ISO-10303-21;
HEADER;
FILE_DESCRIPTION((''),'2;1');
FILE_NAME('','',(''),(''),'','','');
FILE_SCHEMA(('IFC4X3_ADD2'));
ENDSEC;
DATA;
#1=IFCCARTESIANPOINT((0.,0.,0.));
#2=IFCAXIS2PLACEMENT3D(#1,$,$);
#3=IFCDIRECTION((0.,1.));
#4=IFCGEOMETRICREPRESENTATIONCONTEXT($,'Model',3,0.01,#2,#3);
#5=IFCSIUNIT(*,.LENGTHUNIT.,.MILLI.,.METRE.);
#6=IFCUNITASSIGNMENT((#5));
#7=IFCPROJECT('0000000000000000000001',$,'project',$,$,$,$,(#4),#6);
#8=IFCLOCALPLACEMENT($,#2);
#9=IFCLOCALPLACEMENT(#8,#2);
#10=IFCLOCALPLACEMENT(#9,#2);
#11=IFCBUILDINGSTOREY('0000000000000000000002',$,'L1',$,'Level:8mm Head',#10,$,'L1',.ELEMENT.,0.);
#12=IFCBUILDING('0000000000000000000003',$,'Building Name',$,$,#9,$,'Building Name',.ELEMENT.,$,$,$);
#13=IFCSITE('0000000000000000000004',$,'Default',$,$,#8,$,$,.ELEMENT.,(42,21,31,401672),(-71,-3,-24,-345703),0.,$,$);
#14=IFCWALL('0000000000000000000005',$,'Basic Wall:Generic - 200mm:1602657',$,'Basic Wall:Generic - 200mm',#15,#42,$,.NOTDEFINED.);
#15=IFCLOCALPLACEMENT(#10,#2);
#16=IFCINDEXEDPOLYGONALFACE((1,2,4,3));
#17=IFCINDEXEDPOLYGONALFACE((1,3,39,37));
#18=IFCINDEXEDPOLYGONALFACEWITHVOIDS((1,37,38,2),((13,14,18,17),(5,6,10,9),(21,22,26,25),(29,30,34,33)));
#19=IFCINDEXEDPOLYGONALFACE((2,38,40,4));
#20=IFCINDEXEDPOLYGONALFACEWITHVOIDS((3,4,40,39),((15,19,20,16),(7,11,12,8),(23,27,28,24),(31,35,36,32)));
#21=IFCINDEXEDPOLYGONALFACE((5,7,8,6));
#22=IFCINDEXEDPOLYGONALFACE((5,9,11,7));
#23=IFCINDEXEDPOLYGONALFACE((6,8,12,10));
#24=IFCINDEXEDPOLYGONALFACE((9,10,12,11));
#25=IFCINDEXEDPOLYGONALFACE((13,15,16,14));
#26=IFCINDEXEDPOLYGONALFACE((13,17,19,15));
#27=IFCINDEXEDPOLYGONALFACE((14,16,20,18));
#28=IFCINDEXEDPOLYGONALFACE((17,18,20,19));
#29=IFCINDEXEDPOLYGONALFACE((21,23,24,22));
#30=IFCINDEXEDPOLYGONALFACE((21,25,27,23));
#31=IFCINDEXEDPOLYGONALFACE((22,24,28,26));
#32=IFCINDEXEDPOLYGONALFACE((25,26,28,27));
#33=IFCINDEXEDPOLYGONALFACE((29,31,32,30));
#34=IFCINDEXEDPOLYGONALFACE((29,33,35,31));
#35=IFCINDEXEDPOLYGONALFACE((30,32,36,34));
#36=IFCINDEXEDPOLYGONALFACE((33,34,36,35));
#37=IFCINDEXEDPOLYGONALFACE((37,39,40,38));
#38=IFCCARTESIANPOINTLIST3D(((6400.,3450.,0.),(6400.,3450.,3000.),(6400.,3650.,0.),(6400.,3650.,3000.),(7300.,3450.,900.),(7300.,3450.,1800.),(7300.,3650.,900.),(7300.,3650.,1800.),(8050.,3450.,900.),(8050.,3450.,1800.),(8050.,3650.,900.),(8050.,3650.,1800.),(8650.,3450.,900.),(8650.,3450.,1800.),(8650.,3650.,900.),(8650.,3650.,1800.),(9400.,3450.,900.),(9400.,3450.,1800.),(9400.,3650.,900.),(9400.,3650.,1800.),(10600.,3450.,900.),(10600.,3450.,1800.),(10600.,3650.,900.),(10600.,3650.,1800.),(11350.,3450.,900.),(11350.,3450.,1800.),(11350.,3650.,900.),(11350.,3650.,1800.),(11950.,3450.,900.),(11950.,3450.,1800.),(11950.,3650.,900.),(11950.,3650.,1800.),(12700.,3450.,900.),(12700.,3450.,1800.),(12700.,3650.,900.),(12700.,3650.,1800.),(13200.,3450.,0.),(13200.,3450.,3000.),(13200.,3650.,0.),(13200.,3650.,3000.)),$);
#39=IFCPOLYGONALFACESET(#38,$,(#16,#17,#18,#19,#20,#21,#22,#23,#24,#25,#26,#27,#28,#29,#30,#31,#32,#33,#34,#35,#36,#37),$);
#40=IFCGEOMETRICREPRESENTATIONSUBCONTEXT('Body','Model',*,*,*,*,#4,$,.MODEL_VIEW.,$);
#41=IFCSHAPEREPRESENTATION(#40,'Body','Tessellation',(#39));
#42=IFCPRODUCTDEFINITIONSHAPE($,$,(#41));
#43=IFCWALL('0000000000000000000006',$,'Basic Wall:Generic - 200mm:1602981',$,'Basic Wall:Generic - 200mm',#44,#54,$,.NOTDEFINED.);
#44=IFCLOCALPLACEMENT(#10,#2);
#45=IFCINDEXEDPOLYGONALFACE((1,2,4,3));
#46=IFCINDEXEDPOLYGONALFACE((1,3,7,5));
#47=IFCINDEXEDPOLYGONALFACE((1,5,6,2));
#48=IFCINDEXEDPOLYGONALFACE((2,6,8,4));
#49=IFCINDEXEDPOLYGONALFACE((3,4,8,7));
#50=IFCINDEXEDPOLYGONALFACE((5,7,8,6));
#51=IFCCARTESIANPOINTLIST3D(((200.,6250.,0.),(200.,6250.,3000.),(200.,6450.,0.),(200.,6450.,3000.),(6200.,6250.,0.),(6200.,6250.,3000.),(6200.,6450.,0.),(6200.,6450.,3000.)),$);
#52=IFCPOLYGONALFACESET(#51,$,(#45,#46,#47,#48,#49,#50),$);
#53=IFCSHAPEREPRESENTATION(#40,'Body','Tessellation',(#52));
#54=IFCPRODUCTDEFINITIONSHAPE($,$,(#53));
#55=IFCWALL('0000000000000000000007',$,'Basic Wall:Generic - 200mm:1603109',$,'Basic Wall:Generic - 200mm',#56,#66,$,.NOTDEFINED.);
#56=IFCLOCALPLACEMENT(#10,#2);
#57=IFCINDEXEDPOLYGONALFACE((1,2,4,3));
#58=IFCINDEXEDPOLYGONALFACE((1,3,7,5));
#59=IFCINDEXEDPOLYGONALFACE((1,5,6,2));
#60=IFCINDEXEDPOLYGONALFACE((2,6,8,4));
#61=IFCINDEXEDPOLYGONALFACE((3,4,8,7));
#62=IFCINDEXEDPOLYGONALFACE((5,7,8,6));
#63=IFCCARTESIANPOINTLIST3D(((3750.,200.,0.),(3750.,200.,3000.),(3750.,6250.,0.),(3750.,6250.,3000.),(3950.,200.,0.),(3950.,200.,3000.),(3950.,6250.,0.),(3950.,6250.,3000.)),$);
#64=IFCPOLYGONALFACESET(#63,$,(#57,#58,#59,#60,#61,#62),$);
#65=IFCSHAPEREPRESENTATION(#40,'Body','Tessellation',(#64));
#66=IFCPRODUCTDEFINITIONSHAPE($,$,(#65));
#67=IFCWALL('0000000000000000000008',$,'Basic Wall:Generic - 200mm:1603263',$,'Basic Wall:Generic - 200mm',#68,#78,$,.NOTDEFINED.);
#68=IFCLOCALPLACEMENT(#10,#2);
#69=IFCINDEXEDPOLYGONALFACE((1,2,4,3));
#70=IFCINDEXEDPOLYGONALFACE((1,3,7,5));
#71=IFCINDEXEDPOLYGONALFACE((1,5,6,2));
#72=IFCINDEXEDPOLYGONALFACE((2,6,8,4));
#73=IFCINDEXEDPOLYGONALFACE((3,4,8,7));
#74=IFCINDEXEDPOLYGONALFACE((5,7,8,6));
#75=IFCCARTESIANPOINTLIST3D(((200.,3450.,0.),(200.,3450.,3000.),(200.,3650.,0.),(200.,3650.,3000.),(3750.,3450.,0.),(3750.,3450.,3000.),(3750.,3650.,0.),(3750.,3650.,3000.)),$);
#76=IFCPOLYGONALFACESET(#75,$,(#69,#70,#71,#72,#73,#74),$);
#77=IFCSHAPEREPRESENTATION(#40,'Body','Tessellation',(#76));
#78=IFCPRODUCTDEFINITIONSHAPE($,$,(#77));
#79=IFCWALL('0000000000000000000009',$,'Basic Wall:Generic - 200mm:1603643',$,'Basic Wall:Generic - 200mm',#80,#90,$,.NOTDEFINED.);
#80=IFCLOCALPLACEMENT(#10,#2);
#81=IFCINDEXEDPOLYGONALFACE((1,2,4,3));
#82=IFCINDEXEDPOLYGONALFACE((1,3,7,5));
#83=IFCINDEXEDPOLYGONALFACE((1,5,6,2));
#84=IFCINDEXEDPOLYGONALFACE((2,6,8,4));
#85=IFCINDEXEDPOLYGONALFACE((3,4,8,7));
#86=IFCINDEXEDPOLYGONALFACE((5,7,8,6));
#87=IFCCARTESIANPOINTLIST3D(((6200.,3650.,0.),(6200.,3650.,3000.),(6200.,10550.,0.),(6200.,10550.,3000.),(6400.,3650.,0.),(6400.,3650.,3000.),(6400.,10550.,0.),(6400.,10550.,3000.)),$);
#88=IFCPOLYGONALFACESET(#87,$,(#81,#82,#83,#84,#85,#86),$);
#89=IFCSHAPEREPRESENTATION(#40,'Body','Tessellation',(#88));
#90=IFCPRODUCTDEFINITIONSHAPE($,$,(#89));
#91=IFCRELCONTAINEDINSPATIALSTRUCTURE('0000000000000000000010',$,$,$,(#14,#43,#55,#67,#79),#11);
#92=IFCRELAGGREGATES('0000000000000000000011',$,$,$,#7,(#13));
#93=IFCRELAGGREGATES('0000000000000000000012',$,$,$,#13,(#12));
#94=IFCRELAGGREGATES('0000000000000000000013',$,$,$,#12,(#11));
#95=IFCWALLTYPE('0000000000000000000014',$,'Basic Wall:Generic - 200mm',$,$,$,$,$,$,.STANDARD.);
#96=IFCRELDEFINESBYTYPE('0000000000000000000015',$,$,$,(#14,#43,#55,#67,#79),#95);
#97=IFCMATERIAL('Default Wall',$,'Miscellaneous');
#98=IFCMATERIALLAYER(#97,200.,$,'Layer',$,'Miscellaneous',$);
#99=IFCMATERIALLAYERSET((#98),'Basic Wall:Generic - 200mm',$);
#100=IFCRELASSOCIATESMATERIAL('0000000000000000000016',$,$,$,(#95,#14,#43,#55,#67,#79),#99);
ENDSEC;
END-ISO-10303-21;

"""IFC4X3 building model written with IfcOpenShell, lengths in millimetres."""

from ifc_helpers import new_model, si_unit, direction, frame, frame_2d, origin, place, context, subcontext, project, spatial, rectangle, extrude, material, layer, layer_set, type_object, element, save


model = new_model("IFC4X3")

# Units and contexts
model_context = context("Model", 3, precision=0.01, world=origin(), true_north=direction((0.0, 1.0)))
body_context = subcontext(model_context, "Body", "Model", "MODEL_VIEW")
ifc_project = project(units=[si_unit("LENGTHUNIT", "METRE", prefix="MILLI")], contexts=[model_context])

# Site, building, storey
site_placement = place(None, origin())
site = spatial("IfcSite", under=ifc_project, at=site_placement, Name="Default", CompositionType="ELEMENT", RefLatitude=(42, 21, 31, 401672), RefLongitude=(-71, -3, -24, -345703), RefElevation=0.0)
building_placement = place(site_placement, origin())
building = spatial("IfcBuilding", under=site, at=building_placement, Name="Building Name", LongName="Building Name", CompositionType="ELEMENT")
storey_placement = place(building_placement, origin())
storey = spatial("IfcBuildingStorey", under=building, at=storey_placement, Name="L1", ObjectType="Level:8mm Head", LongName="L1", CompositionType="ELEMENT", Elevation=0.0)

# Shared definitions
ifc_material = material(Name="Default Wall", Category="Miscellaneous")
ifc_layer = layer(ifc_material, 200.0, Name="Layer", Category="Miscellaneous")
ifc_layer_set = layer_set([ifc_layer], Name="Basic Wall:Generic - 200mm")
wall_type = type_object("IfcWallType", Name="Basic Wall:Generic - 200mm", PredefinedType="STANDARD", material=ifc_layer_set)

# Wall, openings
wall_1_placement = place(storey_placement, frame((6400.0, 3550.0, 0.0)))
wall_1 = element("IfcWall", 1, at=wall_1_placement, inside=storey, type_object=wall_type, material=ifc_layer_set, Name="Basic Wall:Generic - 200mm:1602657", ObjectType="Basic Wall:Generic - 200mm", PredefinedType="NOTDEFINED", context=body_context, shape_type="SweptSolid", body=[
    extrude(rectangle(XDim=6800.0, YDim=200.0, at=frame_2d((3400.0, 0.0), x_axis=(-1.0, 0.0))), origin(), (0.0, 0.0, 1.0), 3000.0),
])
opening_1_placement = place(wall_1_placement, frame((1650.0, 100.0, 900.0)))
element("IfcOpeningElement", 2, at=opening_1_placement, cuts=wall_1, PredefinedType="OPENING", context=body_context, shape_type="SweptSolid", body=[
    extrude(rectangle(XDim=900.0, YDim=750.0, at=frame_2d((450.0, 375.0), x_axis=(-1.0, 0.0))), frame((0.0, 0.0, 0.0), z_axis=(0.0, -1.0, 0.0), x_axis=(0.0, 0.0, 1.0)), (0.0, 0.0, 1.0), 200.0),
])
opening_2_placement = place(wall_1_placement, frame((3000.0, 100.0, 900.0)))
element("IfcOpeningElement", 3, at=opening_2_placement, cuts=wall_1, PredefinedType="OPENING", context=body_context, shape_type="SweptSolid", body=[
    extrude(rectangle(XDim=900.0, YDim=750.0, at=frame_2d((450.0, 375.0), x_axis=(-1.0, 0.0))), frame((0.0, 0.0, 0.0), z_axis=(0.0, -1.0, 0.0), x_axis=(0.0, 0.0, 1.0)), (0.0, 0.0, 1.0), 200.0),
])
opening_3_placement = place(wall_1_placement, frame((4950.0, 100.0, 900.0)))
element("IfcOpeningElement", 4, at=opening_3_placement, cuts=wall_1, PredefinedType="OPENING", context=body_context, shape_type="SweptSolid", body=[
    extrude(rectangle(XDim=900.0, YDim=750.0, at=frame_2d((450.0, 375.0), x_axis=(-1.0, 0.0))), frame((0.0, 0.0, 0.0), z_axis=(0.0, -1.0, 0.0), x_axis=(0.0, 0.0, 1.0)), (0.0, 0.0, 1.0), 200.0),
])
opening_4_placement = place(wall_1_placement, frame((6300.0, 100.0, 900.0)))
element("IfcOpeningElement", 5, at=opening_4_placement, cuts=wall_1, PredefinedType="OPENING", context=body_context, shape_type="SweptSolid", body=[
    extrude(rectangle(XDim=900.0, YDim=750.0, at=frame_2d((450.0, 375.0), x_axis=(-1.0, 0.0))), frame((0.0, 0.0, 0.0), z_axis=(0.0, -1.0, 0.0), x_axis=(0.0, 0.0, 1.0)), (0.0, 0.0, 1.0), 200.0),
])

# Walls
wall_2_placement = place(storey_placement, frame((6200.0, 6350.0, 0.0), z_axis=(0.0, 0.0, 1.0), x_axis=(-1.0, 0.0, 0.0)))
element("IfcWall", 6, at=wall_2_placement, inside=storey, type_object=wall_type, material=ifc_layer_set, Name="Basic Wall:Generic - 200mm:1602981", ObjectType="Basic Wall:Generic - 200mm", PredefinedType="NOTDEFINED", context=body_context, shape_type="SweptSolid", body=[
    extrude(rectangle(XDim=6000.0, YDim=200.0, at=frame_2d((3000.0, 0.0), x_axis=(-1.0, 0.0))), origin(), (0.0, 0.0, 1.0), 3000.0),
])
wall_3_placement = place(storey_placement, frame((3850.0, 6250.0, 0.0), z_axis=(0.0, 0.0, 1.0), x_axis=(0.0, -1.0, 0.0)))
element("IfcWall", 7, at=wall_3_placement, inside=storey, type_object=wall_type, material=ifc_layer_set, Name="Basic Wall:Generic - 200mm:1603109", ObjectType="Basic Wall:Generic - 200mm", PredefinedType="NOTDEFINED", context=body_context, shape_type="SweptSolid", body=[
    extrude(rectangle(XDim=6050.0, YDim=200.0, at=frame_2d((3025.0, 0.0), x_axis=(-1.0, 0.0))), origin(), (0.0, 0.0, 1.0), 3000.0),
])
wall_4_placement = place(storey_placement, frame((3750.0, 3550.0, 0.0), z_axis=(0.0, 0.0, 1.0), x_axis=(-1.0, 0.0, 0.0)))
element("IfcWall", 8, at=wall_4_placement, inside=storey, type_object=wall_type, material=ifc_layer_set, Name="Basic Wall:Generic - 200mm:1603263", ObjectType="Basic Wall:Generic - 200mm", PredefinedType="NOTDEFINED", context=body_context, shape_type="SweptSolid", body=[
    extrude(rectangle(XDim=3550.0, YDim=200.0, at=frame_2d((1775.0, 0.0), x_axis=(-1.0, 0.0))), origin(), (0.0, 0.0, 1.0), 3000.0),
])
wall_5_placement = place(storey_placement, frame((6300.0, 3650.0, 0.0), z_axis=(0.0, 0.0, 1.0), x_axis=(0.0, 1.0, 0.0)))
element("IfcWall", 9, at=wall_5_placement, inside=storey, type_object=wall_type, material=ifc_layer_set, Name="Basic Wall:Generic - 200mm:1603643", ObjectType="Basic Wall:Generic - 200mm", PredefinedType="NOTDEFINED", context=body_context, shape_type="SweptSolid", body=[
    extrude(rectangle(XDim=6900.0, YDim=200.0, at=frame_2d((3450.0, 0.0), x_axis=(-1.0, 0.0))), origin(), (0.0, 0.0, 1.0), 3000.0),
])

save(model, "model.ifc")
